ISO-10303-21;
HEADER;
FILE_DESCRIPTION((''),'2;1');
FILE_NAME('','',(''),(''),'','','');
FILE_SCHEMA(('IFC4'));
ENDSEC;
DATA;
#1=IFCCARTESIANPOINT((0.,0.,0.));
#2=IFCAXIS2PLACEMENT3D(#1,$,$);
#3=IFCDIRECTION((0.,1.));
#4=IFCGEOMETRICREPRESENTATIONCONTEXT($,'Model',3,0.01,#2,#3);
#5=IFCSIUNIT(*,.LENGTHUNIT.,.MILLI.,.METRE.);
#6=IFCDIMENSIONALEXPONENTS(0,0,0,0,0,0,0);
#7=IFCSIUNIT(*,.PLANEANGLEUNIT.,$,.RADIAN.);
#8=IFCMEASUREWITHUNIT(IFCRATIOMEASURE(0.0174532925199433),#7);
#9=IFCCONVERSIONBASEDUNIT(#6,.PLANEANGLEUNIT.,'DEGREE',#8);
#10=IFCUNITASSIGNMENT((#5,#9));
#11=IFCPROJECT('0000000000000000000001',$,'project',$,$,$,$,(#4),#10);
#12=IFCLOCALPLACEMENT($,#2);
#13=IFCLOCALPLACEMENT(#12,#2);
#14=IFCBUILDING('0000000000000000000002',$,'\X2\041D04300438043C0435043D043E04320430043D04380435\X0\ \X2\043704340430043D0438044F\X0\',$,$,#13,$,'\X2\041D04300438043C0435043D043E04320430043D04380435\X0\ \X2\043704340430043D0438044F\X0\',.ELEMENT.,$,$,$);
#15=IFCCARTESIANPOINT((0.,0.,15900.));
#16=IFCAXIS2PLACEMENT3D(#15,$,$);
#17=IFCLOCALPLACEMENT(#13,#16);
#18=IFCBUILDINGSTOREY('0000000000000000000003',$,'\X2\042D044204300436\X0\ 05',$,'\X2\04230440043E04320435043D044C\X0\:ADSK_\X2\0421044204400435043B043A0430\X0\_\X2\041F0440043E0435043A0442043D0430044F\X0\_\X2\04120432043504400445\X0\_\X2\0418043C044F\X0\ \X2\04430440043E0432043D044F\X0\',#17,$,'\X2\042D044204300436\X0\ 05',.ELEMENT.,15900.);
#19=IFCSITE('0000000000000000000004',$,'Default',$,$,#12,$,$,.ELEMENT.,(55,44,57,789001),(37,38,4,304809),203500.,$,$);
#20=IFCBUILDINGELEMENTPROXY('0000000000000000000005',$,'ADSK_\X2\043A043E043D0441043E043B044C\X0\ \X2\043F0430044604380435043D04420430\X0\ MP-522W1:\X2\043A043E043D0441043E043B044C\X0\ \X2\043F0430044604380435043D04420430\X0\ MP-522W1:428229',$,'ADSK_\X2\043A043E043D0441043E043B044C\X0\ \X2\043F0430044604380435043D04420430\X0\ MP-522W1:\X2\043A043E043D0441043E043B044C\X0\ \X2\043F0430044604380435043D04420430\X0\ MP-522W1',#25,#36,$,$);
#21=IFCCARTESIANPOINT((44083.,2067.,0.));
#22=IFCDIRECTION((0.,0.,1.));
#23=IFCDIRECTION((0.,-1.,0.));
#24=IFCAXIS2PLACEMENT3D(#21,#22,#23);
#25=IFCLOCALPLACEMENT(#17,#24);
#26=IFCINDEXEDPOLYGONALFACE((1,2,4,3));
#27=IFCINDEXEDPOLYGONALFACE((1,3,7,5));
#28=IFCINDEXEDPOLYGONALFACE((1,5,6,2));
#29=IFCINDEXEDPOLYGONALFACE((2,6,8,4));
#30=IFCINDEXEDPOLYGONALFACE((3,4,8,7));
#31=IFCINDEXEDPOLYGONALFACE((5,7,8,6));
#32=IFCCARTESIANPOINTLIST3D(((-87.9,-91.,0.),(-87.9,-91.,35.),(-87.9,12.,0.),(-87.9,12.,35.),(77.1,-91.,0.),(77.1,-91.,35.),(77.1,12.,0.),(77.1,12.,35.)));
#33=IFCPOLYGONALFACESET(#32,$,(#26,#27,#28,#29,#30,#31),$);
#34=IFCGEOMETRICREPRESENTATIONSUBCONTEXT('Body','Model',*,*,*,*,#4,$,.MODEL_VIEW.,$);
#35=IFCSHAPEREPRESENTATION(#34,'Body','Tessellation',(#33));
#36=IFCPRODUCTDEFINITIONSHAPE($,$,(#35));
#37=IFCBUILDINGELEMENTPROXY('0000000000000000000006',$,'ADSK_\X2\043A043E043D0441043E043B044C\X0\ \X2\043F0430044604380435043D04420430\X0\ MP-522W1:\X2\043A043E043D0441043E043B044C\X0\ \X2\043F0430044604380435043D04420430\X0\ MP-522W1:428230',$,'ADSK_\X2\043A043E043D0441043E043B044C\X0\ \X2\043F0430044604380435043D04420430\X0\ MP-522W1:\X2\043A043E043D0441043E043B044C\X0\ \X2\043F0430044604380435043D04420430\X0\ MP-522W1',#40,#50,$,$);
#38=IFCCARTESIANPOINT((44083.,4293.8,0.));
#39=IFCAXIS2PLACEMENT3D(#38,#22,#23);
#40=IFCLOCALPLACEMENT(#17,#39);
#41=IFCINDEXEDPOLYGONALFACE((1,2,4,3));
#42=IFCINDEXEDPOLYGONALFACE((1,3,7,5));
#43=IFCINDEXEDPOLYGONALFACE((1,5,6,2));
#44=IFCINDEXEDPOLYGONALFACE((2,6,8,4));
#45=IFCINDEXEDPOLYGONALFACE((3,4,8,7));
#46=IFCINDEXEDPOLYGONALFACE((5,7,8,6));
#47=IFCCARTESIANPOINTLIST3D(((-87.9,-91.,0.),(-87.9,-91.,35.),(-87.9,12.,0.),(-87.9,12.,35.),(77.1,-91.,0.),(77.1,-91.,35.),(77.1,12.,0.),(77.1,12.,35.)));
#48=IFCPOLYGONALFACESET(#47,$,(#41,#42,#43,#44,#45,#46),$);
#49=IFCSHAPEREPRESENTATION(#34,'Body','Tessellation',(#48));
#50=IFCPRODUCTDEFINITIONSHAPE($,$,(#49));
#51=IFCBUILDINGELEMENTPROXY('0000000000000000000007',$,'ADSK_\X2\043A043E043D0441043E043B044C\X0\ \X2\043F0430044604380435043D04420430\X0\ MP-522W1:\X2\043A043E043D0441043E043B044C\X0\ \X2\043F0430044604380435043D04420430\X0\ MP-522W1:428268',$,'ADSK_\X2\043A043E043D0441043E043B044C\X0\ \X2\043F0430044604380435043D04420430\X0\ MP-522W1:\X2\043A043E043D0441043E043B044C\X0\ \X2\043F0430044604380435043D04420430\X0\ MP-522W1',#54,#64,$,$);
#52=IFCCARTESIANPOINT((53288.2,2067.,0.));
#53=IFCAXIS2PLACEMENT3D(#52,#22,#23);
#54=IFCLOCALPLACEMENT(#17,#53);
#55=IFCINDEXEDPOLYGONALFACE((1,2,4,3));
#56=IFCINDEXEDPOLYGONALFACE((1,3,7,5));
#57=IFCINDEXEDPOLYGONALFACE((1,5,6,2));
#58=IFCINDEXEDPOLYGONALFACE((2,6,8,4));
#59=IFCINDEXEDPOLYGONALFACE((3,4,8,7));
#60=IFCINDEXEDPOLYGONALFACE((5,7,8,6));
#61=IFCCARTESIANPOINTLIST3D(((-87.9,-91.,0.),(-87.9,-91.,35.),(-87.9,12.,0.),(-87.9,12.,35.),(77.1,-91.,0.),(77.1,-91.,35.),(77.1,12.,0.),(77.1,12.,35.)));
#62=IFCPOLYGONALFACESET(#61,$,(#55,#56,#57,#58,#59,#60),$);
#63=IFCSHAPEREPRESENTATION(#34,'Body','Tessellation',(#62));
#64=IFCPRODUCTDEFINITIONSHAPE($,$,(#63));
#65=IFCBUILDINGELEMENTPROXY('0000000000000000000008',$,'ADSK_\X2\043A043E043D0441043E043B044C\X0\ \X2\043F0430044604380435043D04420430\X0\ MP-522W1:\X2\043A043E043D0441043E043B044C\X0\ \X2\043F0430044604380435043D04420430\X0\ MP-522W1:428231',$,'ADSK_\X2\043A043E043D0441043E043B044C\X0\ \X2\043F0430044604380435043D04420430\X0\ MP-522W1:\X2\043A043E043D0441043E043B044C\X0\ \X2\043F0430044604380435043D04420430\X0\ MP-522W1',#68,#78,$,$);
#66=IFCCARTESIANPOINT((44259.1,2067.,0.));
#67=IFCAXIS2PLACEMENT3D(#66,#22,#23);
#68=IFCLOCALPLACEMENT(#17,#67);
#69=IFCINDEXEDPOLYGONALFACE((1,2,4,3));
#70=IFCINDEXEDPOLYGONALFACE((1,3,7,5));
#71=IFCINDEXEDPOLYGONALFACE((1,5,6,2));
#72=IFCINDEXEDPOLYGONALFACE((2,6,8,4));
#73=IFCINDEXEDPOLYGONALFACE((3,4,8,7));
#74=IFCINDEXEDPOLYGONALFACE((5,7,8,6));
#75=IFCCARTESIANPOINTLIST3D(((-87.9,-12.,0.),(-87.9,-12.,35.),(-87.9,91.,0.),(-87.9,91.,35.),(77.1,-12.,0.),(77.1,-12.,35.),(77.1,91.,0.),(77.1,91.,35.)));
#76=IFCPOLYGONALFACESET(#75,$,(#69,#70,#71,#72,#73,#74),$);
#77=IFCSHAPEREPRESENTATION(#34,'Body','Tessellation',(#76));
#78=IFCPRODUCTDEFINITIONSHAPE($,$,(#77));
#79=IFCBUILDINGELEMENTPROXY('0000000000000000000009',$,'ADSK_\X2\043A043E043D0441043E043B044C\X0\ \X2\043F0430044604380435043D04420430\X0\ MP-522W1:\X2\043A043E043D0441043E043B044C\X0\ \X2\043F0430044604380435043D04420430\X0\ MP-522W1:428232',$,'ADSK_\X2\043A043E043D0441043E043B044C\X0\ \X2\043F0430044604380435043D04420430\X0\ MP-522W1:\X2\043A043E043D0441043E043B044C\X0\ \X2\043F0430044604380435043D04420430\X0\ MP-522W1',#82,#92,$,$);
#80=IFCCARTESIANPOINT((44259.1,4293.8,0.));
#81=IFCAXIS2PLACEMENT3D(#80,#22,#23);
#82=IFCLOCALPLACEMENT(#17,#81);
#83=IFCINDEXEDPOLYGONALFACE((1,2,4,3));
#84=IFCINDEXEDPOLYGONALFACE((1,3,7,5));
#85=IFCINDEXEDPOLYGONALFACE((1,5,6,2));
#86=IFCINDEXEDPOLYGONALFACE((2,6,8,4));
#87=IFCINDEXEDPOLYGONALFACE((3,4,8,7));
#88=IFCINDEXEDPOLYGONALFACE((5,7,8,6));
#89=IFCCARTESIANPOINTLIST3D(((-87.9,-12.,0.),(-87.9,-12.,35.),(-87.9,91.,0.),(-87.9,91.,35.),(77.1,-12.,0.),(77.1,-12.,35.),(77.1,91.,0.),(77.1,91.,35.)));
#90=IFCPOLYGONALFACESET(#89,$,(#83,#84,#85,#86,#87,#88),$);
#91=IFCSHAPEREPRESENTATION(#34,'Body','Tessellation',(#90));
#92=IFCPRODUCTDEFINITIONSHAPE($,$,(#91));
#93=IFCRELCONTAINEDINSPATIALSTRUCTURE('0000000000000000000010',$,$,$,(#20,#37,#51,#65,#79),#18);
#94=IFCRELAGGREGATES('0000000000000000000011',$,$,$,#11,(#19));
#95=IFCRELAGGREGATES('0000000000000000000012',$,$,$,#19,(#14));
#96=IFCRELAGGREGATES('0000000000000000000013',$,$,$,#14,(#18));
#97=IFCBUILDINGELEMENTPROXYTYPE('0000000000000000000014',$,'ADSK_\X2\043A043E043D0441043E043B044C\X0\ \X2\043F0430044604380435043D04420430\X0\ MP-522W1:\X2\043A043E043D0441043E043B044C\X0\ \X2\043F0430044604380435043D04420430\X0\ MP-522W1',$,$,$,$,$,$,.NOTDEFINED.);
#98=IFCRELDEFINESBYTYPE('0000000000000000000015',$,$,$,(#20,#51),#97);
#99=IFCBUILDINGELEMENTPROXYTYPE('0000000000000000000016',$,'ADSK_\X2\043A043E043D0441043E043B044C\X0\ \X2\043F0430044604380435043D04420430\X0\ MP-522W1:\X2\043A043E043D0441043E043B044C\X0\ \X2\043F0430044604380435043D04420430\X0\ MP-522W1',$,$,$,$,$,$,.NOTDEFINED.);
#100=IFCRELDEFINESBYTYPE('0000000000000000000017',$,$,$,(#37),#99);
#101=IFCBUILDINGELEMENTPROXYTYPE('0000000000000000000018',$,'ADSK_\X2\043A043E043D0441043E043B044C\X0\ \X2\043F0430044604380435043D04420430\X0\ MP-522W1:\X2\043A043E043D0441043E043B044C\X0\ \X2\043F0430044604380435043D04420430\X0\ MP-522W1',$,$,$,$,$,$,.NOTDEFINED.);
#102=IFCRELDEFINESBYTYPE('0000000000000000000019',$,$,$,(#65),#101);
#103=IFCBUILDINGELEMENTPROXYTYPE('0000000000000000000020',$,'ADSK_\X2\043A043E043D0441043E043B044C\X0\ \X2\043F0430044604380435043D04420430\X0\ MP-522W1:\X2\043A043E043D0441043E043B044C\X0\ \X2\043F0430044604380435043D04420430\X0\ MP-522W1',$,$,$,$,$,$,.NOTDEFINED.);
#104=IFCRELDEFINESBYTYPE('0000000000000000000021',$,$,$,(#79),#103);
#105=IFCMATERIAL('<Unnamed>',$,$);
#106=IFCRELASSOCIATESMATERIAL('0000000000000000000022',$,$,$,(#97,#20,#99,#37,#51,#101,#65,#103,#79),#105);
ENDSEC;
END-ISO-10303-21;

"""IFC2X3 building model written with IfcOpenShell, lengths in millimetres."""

from ifc_helpers import new_model, entity, si_unit, converted_unit, direction, frame, origin, origin_2d_with_axis, place, context, subcontext, project, spatial, rectangle, extrude, source, transform, mapped, material, type_object, type_shapes, element, save


model = new_model("IFC2X3")

# Units and contexts
model_context = context("Model", 3, precision=0.01, world=origin(), true_north=direction((0.0, 1.0)))
body_context = subcontext(model_context, "Body", "Model", "MODEL_VIEW")
ifc_project = project(units=[si_unit("LENGTHUNIT", "METRE", prefix="MILLI"), converted_unit("PLANEANGLEUNIT", "DEGREE", entity("IfcRatioMeasure", 0.0174532925199433), si_unit("PLANEANGLEUNIT", "RADIAN"), dimensions=[0, 0, 0, 0, 0, 0, 0])], contexts=[model_context])

# Site, building, storey
site_placement = place(None, origin())
site = spatial("IfcSite", under=ifc_project, at=site_placement, Name="Default", CompositionType="ELEMENT", RefLatitude=(55, 44, 57, 789001), RefLongitude=(37, 38, 4, 304809), RefElevation=203500.0)
building_placement = place(site_placement, origin())
building = spatial("IfcBuilding", under=site, at=building_placement, Name="Наименование здания", LongName="Наименование здания", CompositionType="ELEMENT")
storey_placement = place(building_placement, frame((0.0, 0.0, 15900.0)))
storey = spatial("IfcBuildingStorey", under=building, at=storey_placement, Name="Этаж 05", ObjectType="Уровень:ADSK_Стрелка_Проектная_Вверх_Имя уровня", LongName="Этаж 05", CompositionType="ELEMENT", Elevation=15900.0)

# Building element proxies
ifc_material = material(Name="<Unnamed>")
building_element_proxy_type_1 = type_object("IfcBuildingElementProxyType", Name="ADSK_консоль пациента MP-522W1:консоль пациента MP-522W1", PredefinedType="NOTDEFINED", material=ifc_material)
shared_shape_1 = source(origin(), body_context, "Body", "SweptSolid", [
    extrude(rectangle(XDim=165.0, YDim=103.0, at=origin_2d_with_axis()), frame((-5.4, -39.5, 0.0), z_axis=(0.0, 0.0, 1.0), x_axis=(-1.0, 0.0, 0.0)), (0.0, 0.0, 1.0), 35.0),
])
type_shapes(building_element_proxy_type_1, [shared_shape_1])
proxy_1_placement = place(storey_placement, frame((44083.0, 2067.0, 0.0), z_axis=(0.0, 0.0, 1.0), x_axis=(0.0, -1.0, 0.0)))
element("IfcBuildingElementProxy", 1, at=proxy_1_placement, inside=storey, type_object=building_element_proxy_type_1, material=ifc_material, Name="ADSK_консоль пациента MP-522W1:консоль пациента MP-522W1:428229", ObjectType="ADSK_консоль пациента MP-522W1:консоль пациента MP-522W1", context=body_context, shape_type="MappedRepresentation", body=[
    mapped(shared_shape_1, transform((0.0, 0.0, 0.0), scale=1.0)),
])
building_element_proxy_type_2 = type_object("IfcBuildingElementProxyType", Name="ADSK_консоль пациента MP-522W1:консоль пациента MP-522W1", PredefinedType="NOTDEFINED", material=ifc_material)
type_shapes(building_element_proxy_type_2, [shared_shape_1])
proxy_2_placement = place(storey_placement, frame((44083.0, 4293.8, 0.0), z_axis=(0.0, 0.0, 1.0), x_axis=(0.0, -1.0, 0.0)))
element("IfcBuildingElementProxy", 2, at=proxy_2_placement, inside=storey, type_object=building_element_proxy_type_2, material=ifc_material, Name="ADSK_консоль пациента MP-522W1:консоль пациента MP-522W1:428230", ObjectType="ADSK_консоль пациента MP-522W1:консоль пациента MP-522W1", context=body_context, shape_type="MappedRepresentation", body=[
    mapped(shared_shape_1, transform((0.0, 0.0, 0.0), scale=1.0)),
])
proxy_3_placement = place(storey_placement, frame((53288.2, 2067.0, 0.0), z_axis=(0.0, 0.0, 1.0), x_axis=(0.0, -1.0, 0.0)))
element("IfcBuildingElementProxy", 3, at=proxy_3_placement, inside=storey, type_object=building_element_proxy_type_1, material=ifc_material, Name="ADSK_консоль пациента MP-522W1:консоль пациента MP-522W1:428268", ObjectType="ADSK_консоль пациента MP-522W1:консоль пациента MP-522W1", context=body_context, shape_type="MappedRepresentation", body=[
    mapped(shared_shape_1, transform((0.0, 0.0, 0.0), scale=1.0)),
])
building_element_proxy_type_3 = type_object("IfcBuildingElementProxyType", Name="ADSK_консоль пациента MP-522W1:консоль пациента MP-522W1", PredefinedType="NOTDEFINED", material=ifc_material)
shared_shape_2 = source(origin(), body_context, "Body", "SweptSolid", [
    extrude(rectangle(XDim=103.0, YDim=165.0, at=origin_2d_with_axis()), frame((-5.4, 39.5, 0.0), z_axis=(0.0, 0.0, 1.0), x_axis=(0.0, 1.0, 0.0)), (0.0, 0.0, 1.0), 35.0),
])
type_shapes(building_element_proxy_type_3, [shared_shape_2])
proxy_4_placement = place(storey_placement, frame((44259.1, 2067.0, 0.0), z_axis=(0.0, 0.0, 1.0), x_axis=(0.0, -1.0, 0.0)))
element("IfcBuildingElementProxy", 4, at=proxy_4_placement, inside=storey, type_object=building_element_proxy_type_3, material=ifc_material, Name="ADSK_консоль пациента MP-522W1:консоль пациента MP-522W1:428231", ObjectType="ADSK_консоль пациента MP-522W1:консоль пациента MP-522W1", context=body_context, shape_type="MappedRepresentation", body=[
    mapped(shared_shape_2, transform((0.0, 0.0, 0.0), scale=1.0)),
])
building_element_proxy_type_4 = type_object("IfcBuildingElementProxyType", Name="ADSK_консоль пациента MP-522W1:консоль пациента MP-522W1", PredefinedType="NOTDEFINED", material=ifc_material)
type_shapes(building_element_proxy_type_4, [shared_shape_2])
proxy_5_placement = place(storey_placement, frame((44259.1, 4293.8, 0.0), z_axis=(0.0, 0.0, 1.0), x_axis=(0.0, -1.0, 0.0)))
element("IfcBuildingElementProxy", 5, at=proxy_5_placement, inside=storey, type_object=building_element_proxy_type_4, material=ifc_material, Name="ADSK_консоль пациента MP-522W1:консоль пациента MP-522W1:428232", ObjectType="ADSK_консоль пациента MP-522W1:консоль пациента MP-522W1", context=body_context, shape_type="MappedRepresentation", body=[
    mapped(shared_shape_2, transform((0.0, 0.0, 0.0), scale=1.0)),
])

save(model, "model.ifc")
